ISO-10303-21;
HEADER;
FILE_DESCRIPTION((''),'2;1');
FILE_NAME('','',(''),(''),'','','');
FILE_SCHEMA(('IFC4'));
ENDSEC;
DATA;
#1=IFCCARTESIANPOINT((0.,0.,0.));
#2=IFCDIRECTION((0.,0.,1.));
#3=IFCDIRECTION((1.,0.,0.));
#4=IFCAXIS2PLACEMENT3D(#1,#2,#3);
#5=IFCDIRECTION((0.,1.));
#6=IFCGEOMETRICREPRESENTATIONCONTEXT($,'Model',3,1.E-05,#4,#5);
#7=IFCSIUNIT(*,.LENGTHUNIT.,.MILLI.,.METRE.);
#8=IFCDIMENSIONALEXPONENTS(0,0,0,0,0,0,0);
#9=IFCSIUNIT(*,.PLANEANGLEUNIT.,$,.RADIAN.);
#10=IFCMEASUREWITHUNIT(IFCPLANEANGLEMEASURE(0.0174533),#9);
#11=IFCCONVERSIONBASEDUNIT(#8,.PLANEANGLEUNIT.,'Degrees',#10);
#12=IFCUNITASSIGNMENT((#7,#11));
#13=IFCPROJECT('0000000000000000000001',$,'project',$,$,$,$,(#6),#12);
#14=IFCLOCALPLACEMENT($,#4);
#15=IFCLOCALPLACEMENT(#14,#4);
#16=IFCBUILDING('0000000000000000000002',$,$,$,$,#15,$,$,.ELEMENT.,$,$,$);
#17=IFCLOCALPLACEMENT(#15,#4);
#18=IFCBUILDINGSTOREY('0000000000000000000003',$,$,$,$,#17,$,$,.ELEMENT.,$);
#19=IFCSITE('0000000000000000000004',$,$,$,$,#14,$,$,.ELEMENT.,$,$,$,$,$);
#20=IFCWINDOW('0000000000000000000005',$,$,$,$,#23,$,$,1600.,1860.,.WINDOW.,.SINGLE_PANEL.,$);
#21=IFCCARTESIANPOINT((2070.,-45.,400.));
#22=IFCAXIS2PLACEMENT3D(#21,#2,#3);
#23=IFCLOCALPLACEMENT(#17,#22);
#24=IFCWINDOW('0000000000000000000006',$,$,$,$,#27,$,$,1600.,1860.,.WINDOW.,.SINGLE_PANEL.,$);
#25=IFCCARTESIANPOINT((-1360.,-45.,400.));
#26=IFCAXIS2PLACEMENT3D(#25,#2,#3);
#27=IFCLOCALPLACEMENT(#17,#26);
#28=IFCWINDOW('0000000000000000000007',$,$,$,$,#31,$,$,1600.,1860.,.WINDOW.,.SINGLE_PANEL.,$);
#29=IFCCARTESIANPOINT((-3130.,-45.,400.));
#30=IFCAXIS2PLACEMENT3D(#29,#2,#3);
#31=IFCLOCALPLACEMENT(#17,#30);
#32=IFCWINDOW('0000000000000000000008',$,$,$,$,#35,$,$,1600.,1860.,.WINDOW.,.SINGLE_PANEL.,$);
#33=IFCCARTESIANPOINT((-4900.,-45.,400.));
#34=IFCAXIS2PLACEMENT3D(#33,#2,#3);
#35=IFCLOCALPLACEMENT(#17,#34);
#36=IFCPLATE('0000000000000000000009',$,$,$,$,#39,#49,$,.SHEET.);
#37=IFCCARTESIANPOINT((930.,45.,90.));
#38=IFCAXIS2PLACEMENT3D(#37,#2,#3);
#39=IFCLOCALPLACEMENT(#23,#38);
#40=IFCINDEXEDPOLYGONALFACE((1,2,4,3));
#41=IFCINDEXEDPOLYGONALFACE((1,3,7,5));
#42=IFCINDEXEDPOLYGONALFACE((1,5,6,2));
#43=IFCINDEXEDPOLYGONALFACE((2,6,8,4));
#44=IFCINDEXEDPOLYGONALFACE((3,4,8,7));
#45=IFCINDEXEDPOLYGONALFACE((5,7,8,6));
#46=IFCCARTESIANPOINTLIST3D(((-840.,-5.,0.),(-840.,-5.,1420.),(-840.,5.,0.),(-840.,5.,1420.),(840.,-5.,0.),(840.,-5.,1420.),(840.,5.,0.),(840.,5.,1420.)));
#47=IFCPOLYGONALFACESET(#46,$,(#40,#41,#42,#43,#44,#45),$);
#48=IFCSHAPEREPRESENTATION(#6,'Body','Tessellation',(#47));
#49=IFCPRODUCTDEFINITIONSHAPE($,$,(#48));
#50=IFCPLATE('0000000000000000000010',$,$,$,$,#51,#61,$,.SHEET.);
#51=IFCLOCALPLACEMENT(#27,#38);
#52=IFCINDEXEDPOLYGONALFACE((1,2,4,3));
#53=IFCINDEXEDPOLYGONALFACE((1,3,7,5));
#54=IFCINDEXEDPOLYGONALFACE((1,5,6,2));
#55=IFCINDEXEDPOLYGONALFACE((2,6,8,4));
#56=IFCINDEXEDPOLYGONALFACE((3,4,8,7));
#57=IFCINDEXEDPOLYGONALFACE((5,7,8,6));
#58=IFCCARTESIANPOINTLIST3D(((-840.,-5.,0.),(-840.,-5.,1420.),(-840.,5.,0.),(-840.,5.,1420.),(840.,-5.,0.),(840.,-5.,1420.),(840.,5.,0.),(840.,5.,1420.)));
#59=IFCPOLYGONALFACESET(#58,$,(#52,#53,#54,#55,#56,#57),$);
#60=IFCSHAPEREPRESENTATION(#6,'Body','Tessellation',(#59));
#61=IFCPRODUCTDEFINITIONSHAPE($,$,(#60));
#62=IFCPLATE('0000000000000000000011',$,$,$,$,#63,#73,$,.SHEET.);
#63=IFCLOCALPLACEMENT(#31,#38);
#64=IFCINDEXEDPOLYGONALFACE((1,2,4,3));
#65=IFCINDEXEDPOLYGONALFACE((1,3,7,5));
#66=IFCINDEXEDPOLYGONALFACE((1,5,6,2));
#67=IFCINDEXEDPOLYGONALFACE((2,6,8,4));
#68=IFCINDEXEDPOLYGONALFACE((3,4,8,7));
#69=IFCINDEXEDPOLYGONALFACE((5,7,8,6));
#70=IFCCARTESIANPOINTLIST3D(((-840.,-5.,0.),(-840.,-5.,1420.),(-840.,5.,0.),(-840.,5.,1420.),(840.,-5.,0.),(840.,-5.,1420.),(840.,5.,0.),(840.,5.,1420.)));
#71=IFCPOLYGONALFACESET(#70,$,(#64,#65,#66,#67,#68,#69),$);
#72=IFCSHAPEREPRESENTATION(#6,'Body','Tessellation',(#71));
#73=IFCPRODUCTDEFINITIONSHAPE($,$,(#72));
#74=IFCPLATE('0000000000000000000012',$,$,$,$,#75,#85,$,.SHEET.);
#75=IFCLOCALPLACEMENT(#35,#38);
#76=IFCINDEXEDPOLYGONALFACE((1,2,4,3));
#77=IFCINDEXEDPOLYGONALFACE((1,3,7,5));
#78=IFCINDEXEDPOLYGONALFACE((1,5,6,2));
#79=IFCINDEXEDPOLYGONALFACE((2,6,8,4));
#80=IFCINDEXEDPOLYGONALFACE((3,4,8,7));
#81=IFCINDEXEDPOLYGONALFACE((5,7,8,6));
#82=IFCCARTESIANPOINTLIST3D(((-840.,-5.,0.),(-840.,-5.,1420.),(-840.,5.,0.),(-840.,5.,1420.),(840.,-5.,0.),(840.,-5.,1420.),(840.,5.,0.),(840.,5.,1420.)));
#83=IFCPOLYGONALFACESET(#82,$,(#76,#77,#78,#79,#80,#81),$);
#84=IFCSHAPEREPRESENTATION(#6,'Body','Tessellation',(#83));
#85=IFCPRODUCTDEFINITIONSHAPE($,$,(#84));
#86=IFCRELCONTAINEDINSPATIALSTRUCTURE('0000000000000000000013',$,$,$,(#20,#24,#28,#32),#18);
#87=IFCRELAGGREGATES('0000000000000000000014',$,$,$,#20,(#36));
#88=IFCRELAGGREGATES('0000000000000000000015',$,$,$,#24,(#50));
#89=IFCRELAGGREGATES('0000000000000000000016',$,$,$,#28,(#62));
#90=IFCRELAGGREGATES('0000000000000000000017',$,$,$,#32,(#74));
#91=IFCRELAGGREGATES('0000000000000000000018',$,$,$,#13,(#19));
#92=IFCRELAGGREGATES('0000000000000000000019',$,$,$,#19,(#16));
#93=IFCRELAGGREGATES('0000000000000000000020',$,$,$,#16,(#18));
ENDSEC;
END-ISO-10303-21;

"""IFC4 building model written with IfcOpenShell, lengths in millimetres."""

from ifc_helpers import new_model, entity, si_unit, converted_unit, direction, frame, origin_with_axes, place, context, project, spatial, polyline, outline, extrude, element, aggregate, save


model = new_model("IFC4")

# Units and contexts
model_context = context("Model", 3, precision=1e-05, world=origin_with_axes(), true_north=direction((0.0, 1.0)))
ifc_project = project(units=[si_unit("LENGTHUNIT", "METRE", prefix="MILLI"), converted_unit("PLANEANGLEUNIT", "Degrees", entity("IfcPlaneAngleMeasure", 0.0174533), si_unit("PLANEANGLEUNIT", "RADIAN"), dimensions=[0, 0, 0, 0, 0, 0, 0])], contexts=[model_context])

# Site, building, storey
site_placement = place(None, origin_with_axes())
site = spatial("IfcSite", under=ifc_project, at=site_placement, CompositionType="ELEMENT")
building_placement = place(site_placement, origin_with_axes())
building = spatial("IfcBuilding", under=site, at=building_placement, CompositionType="ELEMENT")
storey_placement = place(building_placement, origin_with_axes())
storey = spatial("IfcBuildingStorey", under=building, at=storey_placement, CompositionType="ELEMENT")

# Windows
window_1_placement = place(storey_placement, frame((2070.0, -45.0, 400.0), z_axis=(0.0, 0.0, 1.0), x_axis=(1.0, 0.0, 0.0)))
window_1 = element("IfcWindow", 1, at=window_1_placement, inside=storey, OverallHeight=1600.0, OverallWidth=1860.0, PartitioningType="SINGLE_PANEL", PredefinedType="WINDOW")
window_2_placement = place(storey_placement, frame((-1360.0, -45.0, 400.0), z_axis=(0.0, 0.0, 1.0), x_axis=(1.0, 0.0, 0.0)))
window_2 = element("IfcWindow", 2, at=window_2_placement, inside=storey, OverallHeight=1600.0, OverallWidth=1860.0, PartitioningType="SINGLE_PANEL", PredefinedType="WINDOW")
window_3_placement = place(storey_placement, frame((-3130.0, -45.0, 400.0), z_axis=(0.0, 0.0, 1.0), x_axis=(1.0, 0.0, 0.0)))
window_3 = element("IfcWindow", 3, at=window_3_placement, inside=storey, OverallHeight=1600.0, OverallWidth=1860.0, PartitioningType="SINGLE_PANEL", PredefinedType="WINDOW")
window_4_placement = place(storey_placement, frame((-4900.0, -45.0, 400.0), z_axis=(0.0, 0.0, 1.0), x_axis=(1.0, 0.0, 0.0)))
window_4 = element("IfcWindow", 4, at=window_4_placement, inside=storey, OverallHeight=1600.0, OverallWidth=1860.0, PartitioningType="SINGLE_PANEL", PredefinedType="WINDOW")

# Plates
plate_1_placement = place(window_1_placement, frame((930.0, 45.0, 90.0), z_axis=(0.0, 0.0, 1.0), x_axis=(1.0, 0.0, 0.0)))
plate_1 = element("IfcPlate", 5, at=plate_1_placement, PredefinedType="SHEET", context=model_context, shape_type="SweptSolid", body=[
    extrude(outline(polyline([(-840.0, -5.0), (840.0, -5.0), (840.0, 5.0), (-840.0, 5.0), (-840.0, -5.0), (-840.0, -5.0)])), origin_with_axes(), (0.0, 0.0, 1.0), 1420.0),
])
aggregate(window_1, [plate_1])
plate_2_placement = place(window_2_placement, frame((930.0, 45.0, 90.0), z_axis=(0.0, 0.0, 1.0), x_axis=(1.0, 0.0, 0.0)))
plate_2 = element("IfcPlate", 6, at=plate_2_placement, PredefinedType="SHEET", context=model_context, shape_type="SweptSolid", body=[
    extrude(outline(polyline([(-840.0, -5.0), (840.0, -5.0), (840.0, 5.0), (-840.0, 5.0), (-840.0, -5.0), (-840.0, -5.0)])), origin_with_axes(), (0.0, 0.0, 1.0), 1420.0),
])
aggregate(window_2, [plate_2])
plate_3_placement = place(window_3_placement, frame((930.0, 45.0, 90.0), z_axis=(0.0, 0.0, 1.0), x_axis=(1.0, 0.0, 0.0)))
plate_3 = element("IfcPlate", 7, at=plate_3_placement, PredefinedType="SHEET", context=model_context, shape_type="SweptSolid", body=[
    extrude(outline(polyline([(-840.0, -5.0), (840.0, -5.0), (840.0, 5.0), (-840.0, 5.0), (-840.0, -5.0), (-840.0, -5.0)])), origin_with_axes(), (0.0, 0.0, 1.0), 1420.0),
])
aggregate(window_3, [plate_3])
plate_4_placement = place(window_4_placement, frame((930.0, 45.0, 90.0), z_axis=(0.0, 0.0, 1.0), x_axis=(1.0, 0.0, 0.0)))
plate_4 = element("IfcPlate", 8, at=plate_4_placement, PredefinedType="SHEET", context=model_context, shape_type="SweptSolid", body=[
    extrude(outline(polyline([(-840.0, -5.0), (840.0, -5.0), (840.0, 5.0), (-840.0, 5.0), (-840.0, -5.0), (-840.0, -5.0)])), origin_with_axes(), (0.0, 0.0, 1.0), 1420.0),
])
aggregate(window_4, [plate_4])

save(model, "model.ifc")
